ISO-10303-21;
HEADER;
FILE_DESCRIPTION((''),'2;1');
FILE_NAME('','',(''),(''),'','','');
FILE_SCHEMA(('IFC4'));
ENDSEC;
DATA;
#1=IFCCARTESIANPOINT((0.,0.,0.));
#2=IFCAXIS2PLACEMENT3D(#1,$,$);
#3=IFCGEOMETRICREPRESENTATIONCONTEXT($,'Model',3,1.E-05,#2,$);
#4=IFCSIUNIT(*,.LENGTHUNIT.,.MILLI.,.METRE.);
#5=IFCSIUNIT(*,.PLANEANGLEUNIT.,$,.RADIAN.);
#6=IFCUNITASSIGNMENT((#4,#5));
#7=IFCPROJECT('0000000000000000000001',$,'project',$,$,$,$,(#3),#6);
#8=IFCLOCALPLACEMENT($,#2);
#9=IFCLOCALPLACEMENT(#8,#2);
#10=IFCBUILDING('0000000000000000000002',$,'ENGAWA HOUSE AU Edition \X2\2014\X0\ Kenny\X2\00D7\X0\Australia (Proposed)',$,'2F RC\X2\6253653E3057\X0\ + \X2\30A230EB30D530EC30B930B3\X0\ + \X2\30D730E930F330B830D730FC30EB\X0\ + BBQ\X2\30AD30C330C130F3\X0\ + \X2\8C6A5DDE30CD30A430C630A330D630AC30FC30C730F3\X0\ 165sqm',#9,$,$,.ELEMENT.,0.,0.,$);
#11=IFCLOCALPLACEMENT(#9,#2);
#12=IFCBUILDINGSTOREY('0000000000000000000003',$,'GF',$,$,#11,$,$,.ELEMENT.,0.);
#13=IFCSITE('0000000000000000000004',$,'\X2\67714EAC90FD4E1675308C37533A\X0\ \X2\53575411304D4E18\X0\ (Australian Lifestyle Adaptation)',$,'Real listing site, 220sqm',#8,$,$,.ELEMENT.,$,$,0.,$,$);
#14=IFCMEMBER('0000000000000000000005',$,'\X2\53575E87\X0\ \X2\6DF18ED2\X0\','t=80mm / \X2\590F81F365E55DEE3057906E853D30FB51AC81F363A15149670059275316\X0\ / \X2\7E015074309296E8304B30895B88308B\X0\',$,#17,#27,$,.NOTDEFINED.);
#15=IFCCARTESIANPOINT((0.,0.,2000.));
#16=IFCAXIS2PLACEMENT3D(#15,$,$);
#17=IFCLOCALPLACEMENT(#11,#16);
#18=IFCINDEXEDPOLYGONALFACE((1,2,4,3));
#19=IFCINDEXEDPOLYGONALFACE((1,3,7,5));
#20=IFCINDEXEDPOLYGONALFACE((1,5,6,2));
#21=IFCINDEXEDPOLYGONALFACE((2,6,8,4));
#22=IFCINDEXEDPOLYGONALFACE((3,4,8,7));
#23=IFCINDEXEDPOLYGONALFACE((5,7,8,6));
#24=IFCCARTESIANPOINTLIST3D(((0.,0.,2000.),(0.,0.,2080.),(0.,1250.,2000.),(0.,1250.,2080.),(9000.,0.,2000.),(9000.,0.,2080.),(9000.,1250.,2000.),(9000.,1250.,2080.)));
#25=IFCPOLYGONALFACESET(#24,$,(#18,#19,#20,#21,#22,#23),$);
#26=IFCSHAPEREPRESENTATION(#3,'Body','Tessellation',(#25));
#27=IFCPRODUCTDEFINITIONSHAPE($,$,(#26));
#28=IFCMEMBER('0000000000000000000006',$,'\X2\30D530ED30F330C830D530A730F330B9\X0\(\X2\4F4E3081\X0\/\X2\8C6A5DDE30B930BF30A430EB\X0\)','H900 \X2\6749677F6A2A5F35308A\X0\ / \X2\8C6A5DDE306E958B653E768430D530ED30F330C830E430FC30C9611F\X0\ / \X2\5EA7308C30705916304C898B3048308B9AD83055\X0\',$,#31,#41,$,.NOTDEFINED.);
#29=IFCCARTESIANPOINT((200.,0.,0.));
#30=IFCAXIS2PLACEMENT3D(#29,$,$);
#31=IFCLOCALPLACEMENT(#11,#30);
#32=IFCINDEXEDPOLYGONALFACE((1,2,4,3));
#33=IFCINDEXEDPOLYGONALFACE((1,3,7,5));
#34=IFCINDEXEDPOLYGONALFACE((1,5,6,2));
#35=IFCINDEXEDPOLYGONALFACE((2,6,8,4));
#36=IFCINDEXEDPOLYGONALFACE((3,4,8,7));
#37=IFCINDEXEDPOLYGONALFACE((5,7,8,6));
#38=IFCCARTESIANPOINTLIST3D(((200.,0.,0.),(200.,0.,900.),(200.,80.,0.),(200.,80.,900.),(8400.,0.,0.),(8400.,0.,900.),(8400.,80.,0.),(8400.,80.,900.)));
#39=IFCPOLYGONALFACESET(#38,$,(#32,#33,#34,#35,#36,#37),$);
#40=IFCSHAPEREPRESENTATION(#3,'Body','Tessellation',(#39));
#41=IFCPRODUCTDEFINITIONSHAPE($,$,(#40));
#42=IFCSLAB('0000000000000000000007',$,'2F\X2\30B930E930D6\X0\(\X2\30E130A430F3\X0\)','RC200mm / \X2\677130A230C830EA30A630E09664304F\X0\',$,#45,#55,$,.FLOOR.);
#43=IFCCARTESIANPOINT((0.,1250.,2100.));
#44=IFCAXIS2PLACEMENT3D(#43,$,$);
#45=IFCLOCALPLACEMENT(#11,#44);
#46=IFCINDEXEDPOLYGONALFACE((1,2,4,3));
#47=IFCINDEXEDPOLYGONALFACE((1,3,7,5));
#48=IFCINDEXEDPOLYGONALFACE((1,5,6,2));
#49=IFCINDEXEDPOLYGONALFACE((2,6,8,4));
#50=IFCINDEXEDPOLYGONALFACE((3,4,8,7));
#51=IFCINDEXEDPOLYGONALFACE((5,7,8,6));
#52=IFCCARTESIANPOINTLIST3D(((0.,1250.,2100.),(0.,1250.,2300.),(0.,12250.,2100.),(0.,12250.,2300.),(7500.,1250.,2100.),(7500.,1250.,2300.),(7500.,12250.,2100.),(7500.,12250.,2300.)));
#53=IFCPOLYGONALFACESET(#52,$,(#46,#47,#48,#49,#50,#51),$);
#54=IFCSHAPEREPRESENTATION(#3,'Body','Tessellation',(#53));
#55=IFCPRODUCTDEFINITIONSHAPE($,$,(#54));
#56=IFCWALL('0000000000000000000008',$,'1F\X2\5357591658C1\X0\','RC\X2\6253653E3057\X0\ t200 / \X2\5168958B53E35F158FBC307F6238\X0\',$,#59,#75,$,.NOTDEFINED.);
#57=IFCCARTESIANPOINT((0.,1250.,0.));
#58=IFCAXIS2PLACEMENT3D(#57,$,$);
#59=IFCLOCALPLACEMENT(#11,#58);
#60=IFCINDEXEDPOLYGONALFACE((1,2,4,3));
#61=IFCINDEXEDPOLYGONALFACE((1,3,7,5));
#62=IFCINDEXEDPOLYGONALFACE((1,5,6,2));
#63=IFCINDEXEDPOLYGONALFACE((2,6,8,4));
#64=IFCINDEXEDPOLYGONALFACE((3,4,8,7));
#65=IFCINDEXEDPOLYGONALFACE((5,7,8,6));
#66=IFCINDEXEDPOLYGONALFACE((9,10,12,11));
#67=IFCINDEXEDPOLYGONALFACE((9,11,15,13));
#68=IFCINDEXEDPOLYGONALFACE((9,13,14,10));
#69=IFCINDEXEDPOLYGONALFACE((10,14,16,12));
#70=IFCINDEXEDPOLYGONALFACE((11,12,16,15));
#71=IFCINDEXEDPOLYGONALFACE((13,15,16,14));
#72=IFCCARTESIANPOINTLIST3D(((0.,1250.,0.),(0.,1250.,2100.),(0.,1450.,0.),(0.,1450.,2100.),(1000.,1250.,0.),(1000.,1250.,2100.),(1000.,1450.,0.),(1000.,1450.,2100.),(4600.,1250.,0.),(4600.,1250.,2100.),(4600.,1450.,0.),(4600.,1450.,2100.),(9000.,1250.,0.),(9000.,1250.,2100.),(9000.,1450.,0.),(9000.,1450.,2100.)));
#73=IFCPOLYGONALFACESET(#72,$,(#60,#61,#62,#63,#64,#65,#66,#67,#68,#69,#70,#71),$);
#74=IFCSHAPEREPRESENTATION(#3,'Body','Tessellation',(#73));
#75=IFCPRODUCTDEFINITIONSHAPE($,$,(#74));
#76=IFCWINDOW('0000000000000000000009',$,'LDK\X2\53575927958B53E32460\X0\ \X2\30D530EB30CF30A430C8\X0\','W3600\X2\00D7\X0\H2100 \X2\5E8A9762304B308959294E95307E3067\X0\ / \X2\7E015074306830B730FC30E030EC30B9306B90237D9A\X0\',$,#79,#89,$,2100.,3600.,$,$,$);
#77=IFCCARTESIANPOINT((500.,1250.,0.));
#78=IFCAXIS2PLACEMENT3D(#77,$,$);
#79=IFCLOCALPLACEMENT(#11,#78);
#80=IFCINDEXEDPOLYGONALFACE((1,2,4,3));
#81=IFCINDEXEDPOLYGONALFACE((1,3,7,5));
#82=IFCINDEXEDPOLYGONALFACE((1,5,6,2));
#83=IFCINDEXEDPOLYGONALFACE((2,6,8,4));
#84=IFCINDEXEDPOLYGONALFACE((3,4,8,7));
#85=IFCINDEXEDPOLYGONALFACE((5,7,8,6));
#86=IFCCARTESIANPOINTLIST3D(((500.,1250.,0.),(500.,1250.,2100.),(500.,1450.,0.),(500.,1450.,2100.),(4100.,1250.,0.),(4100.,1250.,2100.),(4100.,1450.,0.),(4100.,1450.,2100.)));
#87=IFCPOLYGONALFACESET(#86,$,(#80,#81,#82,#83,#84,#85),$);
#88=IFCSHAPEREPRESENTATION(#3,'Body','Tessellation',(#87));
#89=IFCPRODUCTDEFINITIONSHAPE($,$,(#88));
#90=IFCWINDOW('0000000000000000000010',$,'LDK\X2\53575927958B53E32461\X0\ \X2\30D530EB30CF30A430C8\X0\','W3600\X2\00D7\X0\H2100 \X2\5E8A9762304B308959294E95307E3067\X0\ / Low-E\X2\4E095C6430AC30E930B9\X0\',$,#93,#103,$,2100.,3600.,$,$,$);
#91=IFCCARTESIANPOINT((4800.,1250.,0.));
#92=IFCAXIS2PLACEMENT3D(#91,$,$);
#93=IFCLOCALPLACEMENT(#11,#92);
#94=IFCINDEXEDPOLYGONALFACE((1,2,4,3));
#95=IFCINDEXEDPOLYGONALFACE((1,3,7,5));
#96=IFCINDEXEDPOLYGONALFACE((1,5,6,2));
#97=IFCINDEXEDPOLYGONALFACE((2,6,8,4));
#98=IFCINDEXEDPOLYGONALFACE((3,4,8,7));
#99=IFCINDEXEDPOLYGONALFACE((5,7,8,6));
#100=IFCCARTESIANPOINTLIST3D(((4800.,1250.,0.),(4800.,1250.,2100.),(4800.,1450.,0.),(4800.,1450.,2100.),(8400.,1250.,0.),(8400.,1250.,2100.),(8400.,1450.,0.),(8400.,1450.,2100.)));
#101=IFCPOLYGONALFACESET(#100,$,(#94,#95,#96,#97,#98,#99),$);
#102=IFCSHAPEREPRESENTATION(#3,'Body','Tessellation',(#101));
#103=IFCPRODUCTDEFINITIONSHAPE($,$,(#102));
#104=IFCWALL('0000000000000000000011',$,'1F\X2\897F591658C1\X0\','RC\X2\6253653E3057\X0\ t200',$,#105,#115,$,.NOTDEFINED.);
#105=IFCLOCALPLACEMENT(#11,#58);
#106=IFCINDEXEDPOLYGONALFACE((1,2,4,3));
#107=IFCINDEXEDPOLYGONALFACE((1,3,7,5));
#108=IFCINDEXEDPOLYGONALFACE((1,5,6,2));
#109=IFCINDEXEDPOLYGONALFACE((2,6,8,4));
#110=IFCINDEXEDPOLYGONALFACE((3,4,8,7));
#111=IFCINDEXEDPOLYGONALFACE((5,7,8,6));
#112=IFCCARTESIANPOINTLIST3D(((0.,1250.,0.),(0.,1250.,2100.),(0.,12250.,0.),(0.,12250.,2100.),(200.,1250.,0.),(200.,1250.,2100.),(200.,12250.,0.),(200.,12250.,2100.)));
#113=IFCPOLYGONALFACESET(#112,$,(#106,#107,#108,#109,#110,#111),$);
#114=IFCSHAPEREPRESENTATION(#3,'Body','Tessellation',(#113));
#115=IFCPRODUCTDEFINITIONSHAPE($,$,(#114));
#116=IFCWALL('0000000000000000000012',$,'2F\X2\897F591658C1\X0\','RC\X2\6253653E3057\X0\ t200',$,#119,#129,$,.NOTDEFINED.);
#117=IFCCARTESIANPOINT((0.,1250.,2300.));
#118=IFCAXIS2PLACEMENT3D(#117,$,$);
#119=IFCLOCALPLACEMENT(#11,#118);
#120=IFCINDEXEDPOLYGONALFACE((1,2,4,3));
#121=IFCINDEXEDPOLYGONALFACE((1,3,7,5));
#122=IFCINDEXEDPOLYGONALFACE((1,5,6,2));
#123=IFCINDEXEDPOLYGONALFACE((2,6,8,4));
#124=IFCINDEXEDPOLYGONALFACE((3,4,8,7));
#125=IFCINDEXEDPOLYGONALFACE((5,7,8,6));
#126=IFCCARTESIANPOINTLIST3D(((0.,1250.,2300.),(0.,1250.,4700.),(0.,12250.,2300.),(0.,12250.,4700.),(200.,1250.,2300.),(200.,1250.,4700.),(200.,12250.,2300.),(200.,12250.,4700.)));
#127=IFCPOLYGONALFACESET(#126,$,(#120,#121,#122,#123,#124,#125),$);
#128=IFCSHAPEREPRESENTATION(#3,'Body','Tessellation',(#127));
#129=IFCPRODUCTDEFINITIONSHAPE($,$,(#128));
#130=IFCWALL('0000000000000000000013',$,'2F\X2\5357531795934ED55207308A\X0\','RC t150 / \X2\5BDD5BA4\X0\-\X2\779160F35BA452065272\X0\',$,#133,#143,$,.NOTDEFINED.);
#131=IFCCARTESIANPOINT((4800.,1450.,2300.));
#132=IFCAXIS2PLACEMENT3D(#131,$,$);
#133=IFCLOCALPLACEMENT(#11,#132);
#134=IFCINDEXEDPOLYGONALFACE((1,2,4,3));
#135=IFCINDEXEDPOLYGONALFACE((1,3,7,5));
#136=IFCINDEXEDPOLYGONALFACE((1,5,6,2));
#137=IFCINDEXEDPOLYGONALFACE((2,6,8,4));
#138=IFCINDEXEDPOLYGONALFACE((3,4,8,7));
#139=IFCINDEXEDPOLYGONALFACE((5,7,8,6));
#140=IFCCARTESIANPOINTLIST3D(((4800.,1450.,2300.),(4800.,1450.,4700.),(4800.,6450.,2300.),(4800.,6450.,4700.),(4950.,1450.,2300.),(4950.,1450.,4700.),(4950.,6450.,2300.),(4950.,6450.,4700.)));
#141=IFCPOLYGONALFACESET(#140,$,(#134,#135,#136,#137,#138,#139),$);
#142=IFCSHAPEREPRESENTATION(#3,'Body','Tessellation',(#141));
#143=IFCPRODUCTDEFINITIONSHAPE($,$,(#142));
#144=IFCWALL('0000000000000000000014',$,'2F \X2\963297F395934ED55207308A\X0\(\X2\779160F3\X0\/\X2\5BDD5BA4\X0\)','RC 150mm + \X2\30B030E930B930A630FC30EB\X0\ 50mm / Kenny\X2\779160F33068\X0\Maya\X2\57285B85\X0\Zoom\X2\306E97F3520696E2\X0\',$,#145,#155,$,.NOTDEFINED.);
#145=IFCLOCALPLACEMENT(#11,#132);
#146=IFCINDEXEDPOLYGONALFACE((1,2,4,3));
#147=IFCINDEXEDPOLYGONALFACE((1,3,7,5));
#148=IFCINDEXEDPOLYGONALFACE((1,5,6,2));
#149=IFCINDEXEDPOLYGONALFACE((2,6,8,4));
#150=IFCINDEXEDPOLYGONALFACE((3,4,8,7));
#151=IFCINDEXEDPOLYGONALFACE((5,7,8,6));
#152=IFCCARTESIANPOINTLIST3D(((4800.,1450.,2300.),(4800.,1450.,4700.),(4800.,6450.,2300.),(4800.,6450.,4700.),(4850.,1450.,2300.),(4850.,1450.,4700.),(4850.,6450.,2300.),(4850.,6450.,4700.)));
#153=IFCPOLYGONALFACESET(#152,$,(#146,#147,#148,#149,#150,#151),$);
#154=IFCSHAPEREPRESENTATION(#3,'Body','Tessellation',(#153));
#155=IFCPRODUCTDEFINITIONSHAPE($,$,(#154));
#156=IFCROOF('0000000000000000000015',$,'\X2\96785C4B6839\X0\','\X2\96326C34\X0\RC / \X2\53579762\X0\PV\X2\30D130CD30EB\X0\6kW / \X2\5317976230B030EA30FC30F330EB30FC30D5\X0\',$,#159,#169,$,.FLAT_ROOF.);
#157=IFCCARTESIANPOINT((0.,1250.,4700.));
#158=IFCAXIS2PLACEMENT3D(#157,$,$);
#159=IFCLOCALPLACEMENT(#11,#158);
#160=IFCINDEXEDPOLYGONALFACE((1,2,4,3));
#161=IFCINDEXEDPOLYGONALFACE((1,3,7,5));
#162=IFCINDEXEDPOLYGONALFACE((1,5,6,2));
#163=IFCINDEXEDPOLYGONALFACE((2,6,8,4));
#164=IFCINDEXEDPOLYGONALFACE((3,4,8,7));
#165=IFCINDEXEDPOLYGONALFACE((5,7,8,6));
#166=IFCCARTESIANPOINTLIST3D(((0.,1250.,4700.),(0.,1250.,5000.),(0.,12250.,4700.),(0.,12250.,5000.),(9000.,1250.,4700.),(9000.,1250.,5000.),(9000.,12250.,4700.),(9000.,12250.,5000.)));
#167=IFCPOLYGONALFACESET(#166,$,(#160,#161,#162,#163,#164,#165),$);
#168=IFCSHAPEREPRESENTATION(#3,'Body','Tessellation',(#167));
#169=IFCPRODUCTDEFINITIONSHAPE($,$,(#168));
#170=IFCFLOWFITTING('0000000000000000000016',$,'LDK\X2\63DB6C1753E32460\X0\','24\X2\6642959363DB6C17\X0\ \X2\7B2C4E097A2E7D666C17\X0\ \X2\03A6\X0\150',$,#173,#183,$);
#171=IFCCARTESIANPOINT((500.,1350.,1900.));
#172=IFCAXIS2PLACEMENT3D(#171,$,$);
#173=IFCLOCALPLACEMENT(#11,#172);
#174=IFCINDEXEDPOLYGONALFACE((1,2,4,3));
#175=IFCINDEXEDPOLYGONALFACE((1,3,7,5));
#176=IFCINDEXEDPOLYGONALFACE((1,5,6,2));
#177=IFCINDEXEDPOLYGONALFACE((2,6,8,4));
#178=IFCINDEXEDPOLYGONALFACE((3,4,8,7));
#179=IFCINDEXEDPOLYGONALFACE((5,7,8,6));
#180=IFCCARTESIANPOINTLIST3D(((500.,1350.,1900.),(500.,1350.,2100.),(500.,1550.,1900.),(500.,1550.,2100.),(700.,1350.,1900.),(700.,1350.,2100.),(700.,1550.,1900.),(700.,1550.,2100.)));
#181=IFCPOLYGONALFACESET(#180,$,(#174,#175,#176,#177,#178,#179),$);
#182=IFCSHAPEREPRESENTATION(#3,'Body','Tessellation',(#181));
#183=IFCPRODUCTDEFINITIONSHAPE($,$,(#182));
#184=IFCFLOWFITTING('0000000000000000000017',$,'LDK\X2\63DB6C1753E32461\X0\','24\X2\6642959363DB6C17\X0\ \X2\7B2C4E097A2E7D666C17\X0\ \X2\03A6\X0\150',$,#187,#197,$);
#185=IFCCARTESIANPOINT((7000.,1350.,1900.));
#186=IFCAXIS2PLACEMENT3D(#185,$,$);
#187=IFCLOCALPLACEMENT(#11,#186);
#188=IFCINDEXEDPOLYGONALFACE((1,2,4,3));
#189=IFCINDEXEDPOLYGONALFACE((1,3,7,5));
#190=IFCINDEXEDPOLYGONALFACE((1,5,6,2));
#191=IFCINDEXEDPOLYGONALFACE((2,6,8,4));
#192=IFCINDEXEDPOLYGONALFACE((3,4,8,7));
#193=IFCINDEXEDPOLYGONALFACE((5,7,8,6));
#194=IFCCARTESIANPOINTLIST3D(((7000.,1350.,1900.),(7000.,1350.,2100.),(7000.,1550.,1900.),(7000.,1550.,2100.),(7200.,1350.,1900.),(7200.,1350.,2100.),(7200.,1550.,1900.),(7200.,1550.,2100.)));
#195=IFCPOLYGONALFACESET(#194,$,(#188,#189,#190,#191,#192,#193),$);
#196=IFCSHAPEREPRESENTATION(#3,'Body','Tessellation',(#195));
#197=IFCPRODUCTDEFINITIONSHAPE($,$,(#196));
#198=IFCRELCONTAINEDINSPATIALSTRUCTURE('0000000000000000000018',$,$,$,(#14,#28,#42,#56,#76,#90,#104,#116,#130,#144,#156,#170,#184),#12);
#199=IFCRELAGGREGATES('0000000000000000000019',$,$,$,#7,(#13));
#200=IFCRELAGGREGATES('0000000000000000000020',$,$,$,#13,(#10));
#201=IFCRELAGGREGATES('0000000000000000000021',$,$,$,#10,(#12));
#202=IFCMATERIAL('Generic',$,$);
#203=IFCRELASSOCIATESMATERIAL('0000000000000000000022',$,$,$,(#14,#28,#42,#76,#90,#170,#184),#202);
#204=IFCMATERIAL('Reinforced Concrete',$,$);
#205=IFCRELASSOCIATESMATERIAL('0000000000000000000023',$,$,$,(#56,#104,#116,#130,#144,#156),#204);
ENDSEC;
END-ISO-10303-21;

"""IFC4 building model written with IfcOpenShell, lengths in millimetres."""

from ifc_helpers import new_model, si_unit, frame, frame_2d, origin, place, context, project, spatial, rectangle, extrude, material, element, fill, save


model = new_model("IFC4")

# Units and contexts
model_context = context("Model", 3, precision=1e-05, world=origin())
ifc_project = project(units=[si_unit("LENGTHUNIT", "METRE", prefix="MILLI"), si_unit("PLANEANGLEUNIT", "RADIAN")], contexts=[model_context])

# Site, building, storey
site_placement = place(None, origin())
site = spatial("IfcSite", under=ifc_project, at=site_placement, Name="東京都世田谷区 南向き丘 (Australian Lifestyle Adaptation)", ObjectType="Real listing site, 220sqm", CompositionType="ELEMENT", RefElevation=0.0)
building_placement = place(site_placement, origin())
building = spatial("IfcBuilding", under=site, at=building_placement, Name="ENGAWA HOUSE AU Edition — Kenny×Australia (Proposed)", ObjectType="2F RC打放し + アルフレスコ + プランジプール + BBQキッチン + 豪州ネイティブガーデン 165sqm", CompositionType="ELEMENT", ElevationOfRefHeight=0.0, ElevationOfTerrain=0.0)
storey_placement = place(building_placement, origin())
storey = spatial("IfcBuildingStorey", under=building, at=storey_placement, Name="GF", CompositionType="ELEMENT", Elevation=0.0)

# Members
ifc_material_1 = material(Name="Generic")
member_1_placement = place(storey_placement, frame((0.0, 0.0, 2000.0)))
element("IfcMember", 1, at=member_1_placement, inside=storey, material=ifc_material_1, Name="南庇 深軒", Description="t=80mm / 夏至日差し遮蔽・冬至採光最大化 / 縁側を雨から守る", PredefinedType="NOTDEFINED", context=model_context, shape_type="SweptSolid", body=[
    extrude(rectangle(XDim=9000.0, YDim=1250.0, at=frame_2d((4500.0, 625.0))), frame((0.0, 0.0, 2000.0)), (0.0, 0.0, 1.0), 80.0),
])
member_2_placement = place(storey_placement, frame((200.0, 0.0, 0.0)))
element("IfcMember", 2, at=member_2_placement, inside=storey, material=ifc_material_1, Name="フロントフェンス(低め/豪州スタイル)", Description="H900 杉板横張り / 豪州の開放的フロントヤード感 / 座れば外が見える高さ", PredefinedType="NOTDEFINED", context=model_context, shape_type="SweptSolid", body=[
    extrude(rectangle(XDim=8200.0, YDim=80.0, at=frame_2d((4100.0, 40.0))), frame((200.0, 0.0, 0.0)), (0.0, 0.0, 1.0), 900.0),
])

# Slab
ifc_material_2 = material(Name="Reinforced Concrete")
slab_1_placement = place(storey_placement, frame((0.0, 1250.0, 2100.0)))
element("IfcSlab", 3, at=slab_1_placement, inside=storey, material=ifc_material_1, Name="2Fスラブ(メイン)", Description="RC200mm / 東アトリウム除く", PredefinedType="FLOOR", context=model_context, shape_type="SweptSolid", body=[
    extrude(rectangle(XDim=7500.0, YDim=11000.0, at=frame_2d((3750.0, 5500.0))), frame((0.0, 1250.0, 2100.0)), (0.0, 0.0, 1.0), 200.0),
])

# Wall, openings, windows
wall_1_placement = place(storey_placement, frame((0.0, 1250.0, 0.0)))
wall_1 = element("IfcWall", 4, at=wall_1_placement, inside=storey, material=ifc_material_2, Name="1F南外壁", Description="RC打放し t200 / 全開口引込み戸", PredefinedType="NOTDEFINED", context=model_context, shape_type="SweptSolid", body=[
    extrude(rectangle(XDim=9000.0, YDim=200.0, at=frame_2d((4500.0, 100.0))), frame((0.0, 1250.0, 0.0)), (0.0, 0.0, 1.0), 2100.0),
])
opening_1_placement = place(storey_placement, frame((500.0, 1250.0, 0.0)))
opening_1 = element("IfcOpeningElement", 5, at=opening_1_placement, cuts=wall_1, PredefinedType="NOTDEFINED", context=model_context, shape_type="SweptSolid", body=[
    extrude(rectangle(XDim=3600.0, YDim=200.0, at=frame_2d((1800.0, 100.0))), frame((500.0, 1250.0, 0.0)), (0.0, 0.0, 1.0), 2100.0),
])
opening_2_placement = place(storey_placement, frame((4800.0, 1250.0, 0.0)))
opening_2 = element("IfcOpeningElement", 6, at=opening_2_placement, cuts=wall_1, PredefinedType="NOTDEFINED", context=model_context, shape_type="SweptSolid", body=[
    extrude(rectangle(XDim=3600.0, YDim=200.0, at=frame_2d((1800.0, 100.0))), frame((4800.0, 1250.0, 0.0)), (0.0, 0.0, 1.0), 2100.0),
])
window_1_placement = place(storey_placement, frame((500.0, 1250.0, 0.0)))
window_1 = element("IfcWindow", 7, at=window_1_placement, inside=storey, material=ifc_material_1, Name="LDK南大開口① フルハイト", Description="W3600×H2100 床面から天井まで / 縁側とシームレスに連続", OverallHeight=2100.0, OverallWidth=3600.0, context=model_context, shape_type="SweptSolid", body=[
    extrude(rectangle(XDim=3600.0, YDim=200.0, at=frame_2d((1800.0, 100.0))), frame((500.0, 1250.0, 0.0)), (0.0, 0.0, 1.0), 2100.0),
])
fill(opening_1, window_1)
window_2_placement = place(storey_placement, frame((4800.0, 1250.0, 0.0)))
window_2 = element("IfcWindow", 8, at=window_2_placement, inside=storey, material=ifc_material_1, Name="LDK南大開口② フルハイト", Description="W3600×H2100 床面から天井まで / Low-E三層ガラス", OverallHeight=2100.0, OverallWidth=3600.0, context=model_context, shape_type="SweptSolid", body=[
    extrude(rectangle(XDim=3600.0, YDim=200.0, at=frame_2d((1800.0, 100.0))), frame((4800.0, 1250.0, 0.0)), (0.0, 0.0, 1.0), 2100.0),
])
fill(opening_2, window_2)

# Wall
wall_2_placement = place(storey_placement, frame((0.0, 1250.0, 0.0)))
element("IfcWall", 9, at=wall_2_placement, inside=storey, material=ifc_material_2, Name="1F西外壁", Description="RC打放し t200", PredefinedType="NOTDEFINED", context=model_context, shape_type="SweptSolid", body=[
    extrude(rectangle(XDim=200.0, YDim=11000.0, at=frame_2d((100.0, 5500.0))), frame((0.0, 1250.0, 0.0)), (0.0, 0.0, 1.0), 2100.0),
])

# Wall
wall_3_placement = place(storey_placement, frame((0.0, 1250.0, 2300.0)))
element("IfcWall", 10, at=wall_3_placement, inside=storey, material=ifc_material_2, Name="2F西外壁", Description="RC打放し t200", PredefinedType="NOTDEFINED", context=model_context, shape_type="SweptSolid", body=[
    extrude(rectangle(XDim=200.0, YDim=11000.0, at=frame_2d((100.0, 5500.0))), frame((0.0, 1250.0, 2300.0)), (0.0, 0.0, 1.0), 2400.0),
])

# Walls
wall_4_placement = place(storey_placement, frame((4800.0, 1450.0, 2300.0)))
element("IfcWall", 11, at=wall_4_placement, inside=storey, material=ifc_material_2, Name="2F南北間仕切り", Description="RC t150 / 寝室-瞑想室分割", PredefinedType="NOTDEFINED", context=model_context, shape_type="SweptSolid", body=[
    extrude(rectangle(XDim=150.0, YDim=5000.0, at=frame_2d((75.0, 2500.0))), frame((4800.0, 1450.0, 2300.0)), (0.0, 0.0, 1.0), 2400.0),
])
wall_5_placement = place(storey_placement, frame((4800.0, 1450.0, 2300.0)))
element("IfcWall", 12, at=wall_5_placement, inside=storey, material=ifc_material_2, Name="2F 防音間仕切り(瞑想/寝室)", Description="RC 150mm + グラスウール 50mm / Kenny瞑想とMaya在宅Zoomの音分離", PredefinedType="NOTDEFINED", context=model_context, shape_type="SweptSolid", body=[
    extrude(rectangle(XDim=50.0, YDim=5000.0, at=frame_2d((25.0, 2500.0))), frame((4800.0, 1450.0, 2300.0)), (0.0, 0.0, 1.0), 2400.0),
])

# Roof
roof_placement = place(storey_placement, frame((0.0, 1250.0, 4700.0)))
element("IfcRoof", 13, at=roof_placement, inside=storey, material=ifc_material_2, Name="陸屋根", Description="防水RC / 南面PVパネル6kW / 北面グリーンルーフ", PredefinedType="FLAT_ROOF", context=model_context, shape_type="SweptSolid", body=[
    extrude(rectangle(XDim=9000.0, YDim=11000.0, at=frame_2d((4500.0, 5500.0))), frame((0.0, 1250.0, 4700.0)), (0.0, 0.0, 1.0), 300.0),
])

# Flow fittings
flow_fitting_1_placement = place(storey_placement, frame((500.0, 1350.0, 1900.0)))
element("IfcFlowFitting", 14, at=flow_fitting_1_placement, inside=storey, material=ifc_material_1, Name="LDK換気口①", Description="24時間換気 第三種給気 Φ150", context=model_context, shape_type="SweptSolid", body=[
    extrude(rectangle(XDim=200.0, YDim=200.0, at=frame_2d((100.0, 100.0))), frame((500.0, 1350.0, 1900.0)), (0.0, 0.0, 1.0), 200.0),
])
flow_fitting_2_placement = place(storey_placement, frame((7000.0, 1350.0, 1900.0)))
element("IfcFlowFitting", 15, at=flow_fitting_2_placement, inside=storey, material=ifc_material_1, Name="LDK換気口②", Description="24時間換気 第三種給気 Φ150", context=model_context, shape_type="SweptSolid", body=[
    extrude(rectangle(XDim=200.0, YDim=200.0, at=frame_2d((100.0, 100.0))), frame((7000.0, 1350.0, 1900.0)), (0.0, 0.0, 1.0), 200.0),
])

save(model, "model.ifc")
